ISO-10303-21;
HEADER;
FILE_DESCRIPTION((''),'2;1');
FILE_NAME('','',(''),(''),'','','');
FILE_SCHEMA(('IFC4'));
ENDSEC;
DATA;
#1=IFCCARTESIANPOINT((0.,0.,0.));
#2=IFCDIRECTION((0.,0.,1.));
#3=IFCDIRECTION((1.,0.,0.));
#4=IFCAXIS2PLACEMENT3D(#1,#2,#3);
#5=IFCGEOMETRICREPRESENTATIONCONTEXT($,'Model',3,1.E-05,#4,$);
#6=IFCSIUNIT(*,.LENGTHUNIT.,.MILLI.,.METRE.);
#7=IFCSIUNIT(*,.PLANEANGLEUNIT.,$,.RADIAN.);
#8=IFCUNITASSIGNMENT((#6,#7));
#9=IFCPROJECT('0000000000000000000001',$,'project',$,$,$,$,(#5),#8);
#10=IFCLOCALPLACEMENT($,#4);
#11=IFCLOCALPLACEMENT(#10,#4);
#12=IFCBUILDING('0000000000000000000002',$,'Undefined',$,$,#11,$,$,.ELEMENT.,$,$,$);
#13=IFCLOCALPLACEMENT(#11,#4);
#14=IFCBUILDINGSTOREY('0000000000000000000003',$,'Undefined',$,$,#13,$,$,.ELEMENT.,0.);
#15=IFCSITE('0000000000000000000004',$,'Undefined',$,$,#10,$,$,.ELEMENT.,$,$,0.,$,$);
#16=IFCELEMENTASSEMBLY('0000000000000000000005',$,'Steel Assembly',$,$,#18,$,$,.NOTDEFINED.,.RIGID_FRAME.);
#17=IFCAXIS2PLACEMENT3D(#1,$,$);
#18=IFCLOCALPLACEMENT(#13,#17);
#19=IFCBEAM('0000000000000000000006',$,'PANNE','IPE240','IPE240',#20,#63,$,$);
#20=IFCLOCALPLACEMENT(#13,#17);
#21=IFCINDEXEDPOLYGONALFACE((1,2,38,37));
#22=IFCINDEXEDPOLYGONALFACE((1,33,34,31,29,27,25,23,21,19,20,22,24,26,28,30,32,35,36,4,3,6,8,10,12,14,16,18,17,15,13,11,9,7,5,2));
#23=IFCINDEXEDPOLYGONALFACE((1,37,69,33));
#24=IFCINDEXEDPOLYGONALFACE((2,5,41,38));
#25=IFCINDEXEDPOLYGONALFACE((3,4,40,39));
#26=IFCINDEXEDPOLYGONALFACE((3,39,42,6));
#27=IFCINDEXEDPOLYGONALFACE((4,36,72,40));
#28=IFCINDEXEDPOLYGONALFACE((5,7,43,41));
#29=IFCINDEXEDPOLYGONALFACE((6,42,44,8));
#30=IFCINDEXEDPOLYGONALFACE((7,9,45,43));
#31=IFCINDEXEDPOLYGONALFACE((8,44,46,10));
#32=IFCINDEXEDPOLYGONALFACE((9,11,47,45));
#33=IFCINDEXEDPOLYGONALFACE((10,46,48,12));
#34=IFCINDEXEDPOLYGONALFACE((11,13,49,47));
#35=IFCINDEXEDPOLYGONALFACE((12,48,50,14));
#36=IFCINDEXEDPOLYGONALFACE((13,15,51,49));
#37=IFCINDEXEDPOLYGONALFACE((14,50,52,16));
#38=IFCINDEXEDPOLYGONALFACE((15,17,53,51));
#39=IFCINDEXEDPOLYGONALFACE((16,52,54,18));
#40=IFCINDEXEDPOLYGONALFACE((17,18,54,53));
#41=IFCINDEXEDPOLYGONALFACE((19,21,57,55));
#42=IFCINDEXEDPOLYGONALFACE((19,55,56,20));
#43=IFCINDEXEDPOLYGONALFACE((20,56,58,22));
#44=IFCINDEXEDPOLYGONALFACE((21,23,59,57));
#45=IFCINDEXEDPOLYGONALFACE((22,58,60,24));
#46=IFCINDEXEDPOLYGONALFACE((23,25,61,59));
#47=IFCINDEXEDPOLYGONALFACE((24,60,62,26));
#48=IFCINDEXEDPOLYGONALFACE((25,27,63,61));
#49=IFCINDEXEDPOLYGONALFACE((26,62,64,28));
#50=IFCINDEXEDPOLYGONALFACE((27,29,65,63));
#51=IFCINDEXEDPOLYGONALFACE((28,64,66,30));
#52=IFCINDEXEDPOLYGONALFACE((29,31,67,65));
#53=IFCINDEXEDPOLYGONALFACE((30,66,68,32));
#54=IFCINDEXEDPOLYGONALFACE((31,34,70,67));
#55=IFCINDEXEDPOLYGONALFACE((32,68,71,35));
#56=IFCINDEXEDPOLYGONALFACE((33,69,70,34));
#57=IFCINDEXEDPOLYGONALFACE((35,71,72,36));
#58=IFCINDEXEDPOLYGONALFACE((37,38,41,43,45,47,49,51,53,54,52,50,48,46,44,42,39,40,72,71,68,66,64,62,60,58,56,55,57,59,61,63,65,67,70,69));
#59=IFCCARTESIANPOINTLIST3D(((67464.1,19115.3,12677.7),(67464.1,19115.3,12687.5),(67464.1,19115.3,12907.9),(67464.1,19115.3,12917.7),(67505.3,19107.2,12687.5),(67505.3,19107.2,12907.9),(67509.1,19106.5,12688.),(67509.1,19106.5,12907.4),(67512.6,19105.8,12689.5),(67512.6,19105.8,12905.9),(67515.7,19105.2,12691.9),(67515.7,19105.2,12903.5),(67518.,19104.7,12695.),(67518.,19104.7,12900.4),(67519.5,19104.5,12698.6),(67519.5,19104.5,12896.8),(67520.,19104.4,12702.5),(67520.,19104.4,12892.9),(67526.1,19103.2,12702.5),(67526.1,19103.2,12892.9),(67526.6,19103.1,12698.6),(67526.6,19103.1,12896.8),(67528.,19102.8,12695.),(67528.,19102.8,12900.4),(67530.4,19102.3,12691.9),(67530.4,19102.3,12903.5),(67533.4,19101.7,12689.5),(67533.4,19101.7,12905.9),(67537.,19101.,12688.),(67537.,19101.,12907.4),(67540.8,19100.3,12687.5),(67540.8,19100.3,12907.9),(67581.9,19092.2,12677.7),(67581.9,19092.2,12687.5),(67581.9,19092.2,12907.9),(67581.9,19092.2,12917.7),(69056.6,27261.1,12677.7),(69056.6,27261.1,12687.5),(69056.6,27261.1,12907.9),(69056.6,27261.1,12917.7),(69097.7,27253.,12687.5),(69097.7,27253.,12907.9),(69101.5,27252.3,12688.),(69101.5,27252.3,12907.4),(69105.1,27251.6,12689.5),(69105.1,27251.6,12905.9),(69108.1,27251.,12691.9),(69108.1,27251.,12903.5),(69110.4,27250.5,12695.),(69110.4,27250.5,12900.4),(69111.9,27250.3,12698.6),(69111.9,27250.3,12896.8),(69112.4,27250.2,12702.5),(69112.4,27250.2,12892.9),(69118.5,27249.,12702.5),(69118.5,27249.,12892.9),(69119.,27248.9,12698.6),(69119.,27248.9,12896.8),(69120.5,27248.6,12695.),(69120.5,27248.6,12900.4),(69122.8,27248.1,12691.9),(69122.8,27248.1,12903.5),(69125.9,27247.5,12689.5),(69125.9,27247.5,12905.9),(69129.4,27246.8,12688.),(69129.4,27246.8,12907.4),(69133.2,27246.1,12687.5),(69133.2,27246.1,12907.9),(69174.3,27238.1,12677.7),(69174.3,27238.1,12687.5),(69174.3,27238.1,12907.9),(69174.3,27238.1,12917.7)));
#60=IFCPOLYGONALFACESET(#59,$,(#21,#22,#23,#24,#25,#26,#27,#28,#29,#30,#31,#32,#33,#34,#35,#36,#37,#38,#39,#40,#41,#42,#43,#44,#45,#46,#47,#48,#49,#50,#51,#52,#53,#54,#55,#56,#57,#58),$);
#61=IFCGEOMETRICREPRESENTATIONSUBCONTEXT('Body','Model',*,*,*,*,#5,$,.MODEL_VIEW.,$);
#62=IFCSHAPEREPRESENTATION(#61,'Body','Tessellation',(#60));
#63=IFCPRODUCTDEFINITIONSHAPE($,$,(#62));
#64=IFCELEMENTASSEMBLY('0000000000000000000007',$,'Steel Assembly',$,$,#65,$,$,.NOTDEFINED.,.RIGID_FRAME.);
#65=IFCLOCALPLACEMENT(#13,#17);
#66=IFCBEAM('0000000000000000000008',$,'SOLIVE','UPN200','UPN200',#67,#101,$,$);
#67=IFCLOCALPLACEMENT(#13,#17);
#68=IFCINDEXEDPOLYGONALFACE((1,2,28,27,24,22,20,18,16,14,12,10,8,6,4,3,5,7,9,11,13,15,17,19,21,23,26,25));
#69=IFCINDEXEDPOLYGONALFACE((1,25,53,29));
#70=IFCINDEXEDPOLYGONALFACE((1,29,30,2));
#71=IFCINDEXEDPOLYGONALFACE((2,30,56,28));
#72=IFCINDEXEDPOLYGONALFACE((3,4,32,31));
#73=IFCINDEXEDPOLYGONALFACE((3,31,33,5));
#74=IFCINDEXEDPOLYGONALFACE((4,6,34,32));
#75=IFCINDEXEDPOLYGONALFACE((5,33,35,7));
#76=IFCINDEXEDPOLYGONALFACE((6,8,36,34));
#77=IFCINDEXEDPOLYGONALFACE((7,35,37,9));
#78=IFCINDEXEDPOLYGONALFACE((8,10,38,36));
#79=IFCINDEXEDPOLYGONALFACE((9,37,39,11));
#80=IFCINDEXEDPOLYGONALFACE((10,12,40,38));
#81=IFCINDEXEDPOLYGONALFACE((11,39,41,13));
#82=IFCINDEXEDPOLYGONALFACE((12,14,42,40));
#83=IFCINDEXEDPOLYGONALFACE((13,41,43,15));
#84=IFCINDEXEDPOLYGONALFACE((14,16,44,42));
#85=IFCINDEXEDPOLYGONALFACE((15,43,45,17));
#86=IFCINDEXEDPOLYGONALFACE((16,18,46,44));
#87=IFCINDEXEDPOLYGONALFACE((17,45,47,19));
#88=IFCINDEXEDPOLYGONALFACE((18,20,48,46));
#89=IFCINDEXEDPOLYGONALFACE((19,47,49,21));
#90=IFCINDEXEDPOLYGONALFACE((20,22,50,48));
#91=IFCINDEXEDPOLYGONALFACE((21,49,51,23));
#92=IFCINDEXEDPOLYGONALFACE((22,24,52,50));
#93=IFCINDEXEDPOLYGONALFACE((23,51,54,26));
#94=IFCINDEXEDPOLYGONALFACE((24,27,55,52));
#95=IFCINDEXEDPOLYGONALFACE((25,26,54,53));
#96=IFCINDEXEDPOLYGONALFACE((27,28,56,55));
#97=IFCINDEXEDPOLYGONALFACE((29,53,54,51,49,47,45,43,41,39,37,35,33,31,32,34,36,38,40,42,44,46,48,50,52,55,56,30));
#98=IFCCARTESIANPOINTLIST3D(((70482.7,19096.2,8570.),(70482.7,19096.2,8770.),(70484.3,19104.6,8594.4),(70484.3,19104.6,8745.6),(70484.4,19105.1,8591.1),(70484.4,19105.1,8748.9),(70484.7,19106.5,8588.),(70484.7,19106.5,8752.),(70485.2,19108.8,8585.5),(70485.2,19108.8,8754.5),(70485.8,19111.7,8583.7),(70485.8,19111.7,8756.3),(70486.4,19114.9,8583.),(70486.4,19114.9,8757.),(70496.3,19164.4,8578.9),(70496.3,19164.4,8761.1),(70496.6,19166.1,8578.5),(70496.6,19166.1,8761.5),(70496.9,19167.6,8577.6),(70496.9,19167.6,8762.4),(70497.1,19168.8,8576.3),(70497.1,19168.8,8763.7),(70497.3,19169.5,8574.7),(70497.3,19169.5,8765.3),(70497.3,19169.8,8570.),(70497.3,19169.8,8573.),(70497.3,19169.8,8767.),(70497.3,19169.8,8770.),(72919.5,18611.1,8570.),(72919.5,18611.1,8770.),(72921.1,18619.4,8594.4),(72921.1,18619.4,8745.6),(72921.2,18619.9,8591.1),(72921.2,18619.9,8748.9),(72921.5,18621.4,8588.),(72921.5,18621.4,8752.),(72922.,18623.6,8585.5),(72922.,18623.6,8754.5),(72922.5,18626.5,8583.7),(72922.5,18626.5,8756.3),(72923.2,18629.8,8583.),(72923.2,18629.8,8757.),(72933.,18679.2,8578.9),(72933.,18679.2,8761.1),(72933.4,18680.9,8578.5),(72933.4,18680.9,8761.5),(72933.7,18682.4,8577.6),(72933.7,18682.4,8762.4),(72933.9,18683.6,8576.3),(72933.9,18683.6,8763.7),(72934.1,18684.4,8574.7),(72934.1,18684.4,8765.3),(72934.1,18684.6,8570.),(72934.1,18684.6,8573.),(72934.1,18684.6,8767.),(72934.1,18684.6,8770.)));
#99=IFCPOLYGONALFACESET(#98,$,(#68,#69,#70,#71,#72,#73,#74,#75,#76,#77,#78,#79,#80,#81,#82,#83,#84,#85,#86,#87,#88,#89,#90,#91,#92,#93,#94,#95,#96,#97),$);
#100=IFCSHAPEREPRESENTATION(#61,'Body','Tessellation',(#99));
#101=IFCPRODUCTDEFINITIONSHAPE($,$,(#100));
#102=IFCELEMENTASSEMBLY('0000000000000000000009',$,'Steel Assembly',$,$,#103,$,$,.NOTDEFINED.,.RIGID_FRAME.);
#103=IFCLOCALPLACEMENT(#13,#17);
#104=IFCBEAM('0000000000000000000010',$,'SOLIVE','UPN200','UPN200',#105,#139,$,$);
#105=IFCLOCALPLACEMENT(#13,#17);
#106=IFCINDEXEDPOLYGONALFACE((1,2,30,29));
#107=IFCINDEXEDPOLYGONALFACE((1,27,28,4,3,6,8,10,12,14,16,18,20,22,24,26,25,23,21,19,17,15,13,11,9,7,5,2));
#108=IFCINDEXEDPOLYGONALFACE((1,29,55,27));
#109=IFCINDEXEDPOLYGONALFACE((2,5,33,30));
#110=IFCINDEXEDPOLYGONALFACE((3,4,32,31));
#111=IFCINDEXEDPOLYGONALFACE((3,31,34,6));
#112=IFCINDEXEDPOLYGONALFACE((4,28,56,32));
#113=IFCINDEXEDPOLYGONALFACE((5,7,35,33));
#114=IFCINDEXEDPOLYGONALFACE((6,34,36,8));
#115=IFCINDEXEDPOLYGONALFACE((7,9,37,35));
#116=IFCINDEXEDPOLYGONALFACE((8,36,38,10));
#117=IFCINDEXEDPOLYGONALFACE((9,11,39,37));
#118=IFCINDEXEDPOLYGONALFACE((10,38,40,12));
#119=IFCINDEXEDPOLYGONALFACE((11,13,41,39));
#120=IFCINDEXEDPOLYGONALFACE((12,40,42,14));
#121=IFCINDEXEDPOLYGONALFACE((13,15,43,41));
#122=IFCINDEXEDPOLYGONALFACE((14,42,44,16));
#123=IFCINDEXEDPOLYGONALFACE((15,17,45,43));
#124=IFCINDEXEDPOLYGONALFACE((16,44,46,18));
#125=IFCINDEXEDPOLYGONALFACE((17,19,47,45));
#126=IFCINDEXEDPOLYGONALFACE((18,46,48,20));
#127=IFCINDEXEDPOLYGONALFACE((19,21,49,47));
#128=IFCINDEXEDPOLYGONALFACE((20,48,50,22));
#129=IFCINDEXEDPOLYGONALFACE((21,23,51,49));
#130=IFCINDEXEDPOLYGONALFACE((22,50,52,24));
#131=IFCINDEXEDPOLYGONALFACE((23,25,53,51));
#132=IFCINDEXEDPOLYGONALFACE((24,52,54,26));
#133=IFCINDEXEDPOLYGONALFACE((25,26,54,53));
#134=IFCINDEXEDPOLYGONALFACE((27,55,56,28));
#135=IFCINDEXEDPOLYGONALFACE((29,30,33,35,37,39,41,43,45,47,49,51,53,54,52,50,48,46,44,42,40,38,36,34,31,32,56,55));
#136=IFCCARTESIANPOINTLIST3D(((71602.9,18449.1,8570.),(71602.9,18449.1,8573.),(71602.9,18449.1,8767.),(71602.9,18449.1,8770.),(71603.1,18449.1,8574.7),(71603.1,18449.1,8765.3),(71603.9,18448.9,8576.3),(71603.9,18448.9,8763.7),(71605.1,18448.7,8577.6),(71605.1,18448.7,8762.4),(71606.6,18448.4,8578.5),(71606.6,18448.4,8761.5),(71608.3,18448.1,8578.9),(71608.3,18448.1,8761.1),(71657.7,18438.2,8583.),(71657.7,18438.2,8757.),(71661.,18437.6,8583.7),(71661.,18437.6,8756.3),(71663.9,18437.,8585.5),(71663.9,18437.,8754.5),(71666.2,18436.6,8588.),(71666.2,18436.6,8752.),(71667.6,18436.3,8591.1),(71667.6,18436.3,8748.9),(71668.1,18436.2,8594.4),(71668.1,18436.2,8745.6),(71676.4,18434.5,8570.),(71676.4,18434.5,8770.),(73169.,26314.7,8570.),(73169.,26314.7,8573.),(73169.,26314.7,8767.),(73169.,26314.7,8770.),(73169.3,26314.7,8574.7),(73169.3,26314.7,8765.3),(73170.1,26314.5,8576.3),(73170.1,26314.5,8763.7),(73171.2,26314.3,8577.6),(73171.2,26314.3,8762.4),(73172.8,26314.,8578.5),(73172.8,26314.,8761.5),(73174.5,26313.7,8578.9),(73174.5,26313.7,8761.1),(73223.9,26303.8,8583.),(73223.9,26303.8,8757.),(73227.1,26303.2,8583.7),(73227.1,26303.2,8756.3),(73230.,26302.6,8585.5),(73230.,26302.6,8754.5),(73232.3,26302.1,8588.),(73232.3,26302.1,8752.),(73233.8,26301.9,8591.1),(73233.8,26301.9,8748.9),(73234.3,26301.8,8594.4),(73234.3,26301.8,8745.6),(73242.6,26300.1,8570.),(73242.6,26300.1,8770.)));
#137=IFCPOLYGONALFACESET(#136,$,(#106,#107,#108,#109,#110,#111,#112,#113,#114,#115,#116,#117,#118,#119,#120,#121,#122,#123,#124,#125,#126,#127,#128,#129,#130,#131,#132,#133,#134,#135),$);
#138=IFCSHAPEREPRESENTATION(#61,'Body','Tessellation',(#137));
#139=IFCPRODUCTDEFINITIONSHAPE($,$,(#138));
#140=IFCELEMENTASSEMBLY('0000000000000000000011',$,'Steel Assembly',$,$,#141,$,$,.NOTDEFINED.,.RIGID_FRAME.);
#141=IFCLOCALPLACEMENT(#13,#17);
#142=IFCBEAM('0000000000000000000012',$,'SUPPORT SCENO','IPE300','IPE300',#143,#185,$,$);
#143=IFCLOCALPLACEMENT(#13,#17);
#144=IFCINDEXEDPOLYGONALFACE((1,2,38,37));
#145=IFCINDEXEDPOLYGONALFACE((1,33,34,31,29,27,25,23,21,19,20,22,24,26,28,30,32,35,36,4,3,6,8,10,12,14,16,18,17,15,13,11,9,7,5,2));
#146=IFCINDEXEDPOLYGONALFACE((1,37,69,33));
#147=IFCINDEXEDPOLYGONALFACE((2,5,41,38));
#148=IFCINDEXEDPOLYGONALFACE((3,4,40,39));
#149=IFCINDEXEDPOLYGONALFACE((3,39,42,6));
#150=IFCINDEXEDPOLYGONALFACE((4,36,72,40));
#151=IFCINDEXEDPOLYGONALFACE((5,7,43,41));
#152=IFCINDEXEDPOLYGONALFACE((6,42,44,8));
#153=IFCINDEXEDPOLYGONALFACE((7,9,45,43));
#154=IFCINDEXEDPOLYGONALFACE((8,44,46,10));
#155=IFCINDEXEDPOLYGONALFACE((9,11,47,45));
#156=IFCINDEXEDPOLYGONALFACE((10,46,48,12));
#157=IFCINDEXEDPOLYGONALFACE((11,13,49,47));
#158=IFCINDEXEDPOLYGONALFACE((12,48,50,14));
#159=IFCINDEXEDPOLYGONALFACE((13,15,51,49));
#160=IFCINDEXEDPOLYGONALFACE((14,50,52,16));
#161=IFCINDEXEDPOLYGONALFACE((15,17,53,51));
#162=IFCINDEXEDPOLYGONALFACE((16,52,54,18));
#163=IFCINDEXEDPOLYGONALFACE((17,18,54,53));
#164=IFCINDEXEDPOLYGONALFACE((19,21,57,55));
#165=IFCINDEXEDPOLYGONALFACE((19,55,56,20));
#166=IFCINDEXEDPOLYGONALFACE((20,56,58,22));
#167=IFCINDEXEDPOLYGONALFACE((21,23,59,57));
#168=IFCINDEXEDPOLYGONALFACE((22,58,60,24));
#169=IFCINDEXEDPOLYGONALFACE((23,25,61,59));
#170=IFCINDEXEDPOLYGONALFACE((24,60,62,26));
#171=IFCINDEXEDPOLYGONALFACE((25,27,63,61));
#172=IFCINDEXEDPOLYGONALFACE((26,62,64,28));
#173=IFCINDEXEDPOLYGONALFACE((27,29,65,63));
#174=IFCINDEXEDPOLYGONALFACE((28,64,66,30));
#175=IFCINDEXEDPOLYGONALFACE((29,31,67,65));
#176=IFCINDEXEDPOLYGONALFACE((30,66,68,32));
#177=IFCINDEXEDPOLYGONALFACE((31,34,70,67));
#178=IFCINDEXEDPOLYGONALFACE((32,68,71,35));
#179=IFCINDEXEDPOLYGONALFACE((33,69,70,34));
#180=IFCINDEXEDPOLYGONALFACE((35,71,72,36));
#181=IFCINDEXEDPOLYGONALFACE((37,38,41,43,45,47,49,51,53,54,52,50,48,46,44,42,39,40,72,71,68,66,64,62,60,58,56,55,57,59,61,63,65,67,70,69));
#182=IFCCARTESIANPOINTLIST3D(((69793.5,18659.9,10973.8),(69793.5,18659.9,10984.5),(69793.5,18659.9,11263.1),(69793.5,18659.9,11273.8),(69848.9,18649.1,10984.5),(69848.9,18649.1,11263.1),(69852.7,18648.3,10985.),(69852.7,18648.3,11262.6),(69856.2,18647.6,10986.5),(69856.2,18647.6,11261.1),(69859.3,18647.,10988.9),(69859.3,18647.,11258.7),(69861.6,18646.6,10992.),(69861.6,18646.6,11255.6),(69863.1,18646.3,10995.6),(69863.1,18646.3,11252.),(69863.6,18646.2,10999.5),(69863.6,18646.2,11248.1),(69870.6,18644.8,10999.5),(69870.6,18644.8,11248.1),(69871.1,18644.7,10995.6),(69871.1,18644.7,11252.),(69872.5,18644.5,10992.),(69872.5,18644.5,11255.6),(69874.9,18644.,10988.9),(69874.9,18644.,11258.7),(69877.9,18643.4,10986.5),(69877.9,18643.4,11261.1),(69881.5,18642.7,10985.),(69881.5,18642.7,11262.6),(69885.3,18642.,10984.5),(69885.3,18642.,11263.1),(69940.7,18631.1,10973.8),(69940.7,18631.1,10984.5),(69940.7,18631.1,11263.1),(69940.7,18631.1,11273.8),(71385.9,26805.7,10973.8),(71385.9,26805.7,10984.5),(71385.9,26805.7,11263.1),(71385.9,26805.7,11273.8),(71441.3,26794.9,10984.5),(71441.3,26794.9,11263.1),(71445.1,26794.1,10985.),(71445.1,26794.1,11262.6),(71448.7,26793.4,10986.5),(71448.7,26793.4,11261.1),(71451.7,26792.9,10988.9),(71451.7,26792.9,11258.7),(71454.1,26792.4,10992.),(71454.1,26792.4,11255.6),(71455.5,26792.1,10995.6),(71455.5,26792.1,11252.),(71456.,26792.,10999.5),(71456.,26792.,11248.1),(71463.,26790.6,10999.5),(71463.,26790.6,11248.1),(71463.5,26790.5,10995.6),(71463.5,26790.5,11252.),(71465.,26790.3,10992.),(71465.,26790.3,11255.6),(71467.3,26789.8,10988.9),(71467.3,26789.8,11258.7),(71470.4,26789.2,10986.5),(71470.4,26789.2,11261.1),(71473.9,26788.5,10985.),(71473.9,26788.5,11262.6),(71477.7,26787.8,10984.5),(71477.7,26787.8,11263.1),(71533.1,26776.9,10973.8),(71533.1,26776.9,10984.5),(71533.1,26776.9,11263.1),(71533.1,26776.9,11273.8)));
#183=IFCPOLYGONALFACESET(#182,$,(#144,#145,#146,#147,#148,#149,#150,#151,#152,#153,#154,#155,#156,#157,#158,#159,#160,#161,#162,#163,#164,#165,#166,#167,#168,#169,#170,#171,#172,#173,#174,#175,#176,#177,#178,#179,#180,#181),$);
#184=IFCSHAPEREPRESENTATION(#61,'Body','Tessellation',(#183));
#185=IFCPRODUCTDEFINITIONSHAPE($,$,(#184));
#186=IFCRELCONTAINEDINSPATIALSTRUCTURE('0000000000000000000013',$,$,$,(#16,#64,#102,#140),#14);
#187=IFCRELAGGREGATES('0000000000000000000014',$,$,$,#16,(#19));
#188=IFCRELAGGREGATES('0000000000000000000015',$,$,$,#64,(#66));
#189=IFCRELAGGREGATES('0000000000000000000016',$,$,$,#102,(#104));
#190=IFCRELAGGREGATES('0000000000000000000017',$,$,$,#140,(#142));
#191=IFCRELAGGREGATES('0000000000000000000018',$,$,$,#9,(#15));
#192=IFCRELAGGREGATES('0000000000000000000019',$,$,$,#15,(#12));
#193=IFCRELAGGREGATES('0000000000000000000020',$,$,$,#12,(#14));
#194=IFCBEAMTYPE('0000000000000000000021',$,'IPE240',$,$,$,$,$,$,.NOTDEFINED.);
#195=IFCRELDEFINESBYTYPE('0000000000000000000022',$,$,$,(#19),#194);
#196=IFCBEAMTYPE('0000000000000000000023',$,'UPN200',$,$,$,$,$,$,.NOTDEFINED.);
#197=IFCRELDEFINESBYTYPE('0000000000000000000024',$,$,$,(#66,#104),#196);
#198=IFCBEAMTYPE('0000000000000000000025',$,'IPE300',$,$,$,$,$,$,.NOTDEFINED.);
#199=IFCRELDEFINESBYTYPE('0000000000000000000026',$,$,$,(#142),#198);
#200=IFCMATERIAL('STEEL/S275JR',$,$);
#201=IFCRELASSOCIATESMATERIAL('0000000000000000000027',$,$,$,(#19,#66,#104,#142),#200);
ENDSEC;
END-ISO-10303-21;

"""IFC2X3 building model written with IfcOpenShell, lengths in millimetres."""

from ifc_helpers import new_model, si_unit, frame, origin_with_axes, origin_2d_with_axis, place, context, subcontext, project, spatial, i_section, u_section, extrude, material, type_object, element, aggregate, save


model = new_model("IFC2X3")

# Units and contexts
model_context = context("Model", 3, precision=1e-05, world=origin_with_axes())
body_context = subcontext(model_context, "Body", "Model", "MODEL_VIEW")
ifc_project = project(units=[si_unit("LENGTHUNIT", "METRE", prefix="MILLI"), si_unit("PLANEANGLEUNIT", "RADIAN")], contexts=[model_context])

# Site, building, storey
site_placement = place(None, origin_with_axes())
site = spatial("IfcSite", under=ifc_project, at=site_placement, Name="Undefined", CompositionType="ELEMENT", RefElevation=0.0)
building_placement = place(site_placement, origin_with_axes())
building = spatial("IfcBuilding", under=site, at=building_placement, Name="Undefined", CompositionType="ELEMENT")
storey_placement = place(building_placement, origin_with_axes())
storey = spatial("IfcBuildingStorey", under=building, at=storey_placement, Name="Undefined", CompositionType="ELEMENT", Elevation=0.0)

# Element assemblies, beams
assembly_1_placement = place(storey_placement, origin_with_axes())
assembly_1 = element("IfcElementAssembly", 1, at=assembly_1_placement, inside=storey, Name="Steel Assembly", AssemblyPlace="NOTDEFINED", PredefinedType="RIGID_FRAME")
ifc_material = material(Name="STEEL/S275JR")
beam_type_1 = type_object("IfcBeamType", Name="IPE240", PredefinedType="NOTDEFINED")
beam_1_placement = place(assembly_1_placement, frame((67523.0, 19103.8, 12797.7), z_axis=(0.0, 0.0, 1.0), x_axis=(0.191859, 0.981422, 0.0)))
beam_1 = element("IfcBeam", 2, at=beam_1_placement, type_object=beam_type_1, material=ifc_material, Name="PANNE", Description="IPE240", ObjectType="IPE240", context=body_context, shape_type="SweptSolid", body=[
    extrude(i_section(OverallWidth=120.0, OverallDepth=240.0, WebThickness=6.2, FlangeThickness=9.8, FilletRadius=15.0, at=origin_2d_with_axis()), frame((8300.0, 0.0, 0.0), z_axis=(-1.0, 0.0, 0.0), x_axis=(0.0, -1.0, 0.0)), (0.0, 0.0, 1.0), 8300.0),
])
aggregate(assembly_1, [beam_1])
assembly_2_placement = place(storey_placement, origin_with_axes())
assembly_2 = element("IfcElementAssembly", 3, at=assembly_2_placement, inside=storey, Name="Steel Assembly", AssemblyPlace="NOTDEFINED", PredefinedType="RIGID_FRAME")
beam_type_2 = type_object("IfcBeamType", Name="UPN200", PredefinedType="NOTDEFINED")
beam_2_placement = place(assembly_2_placement, frame((70490.0, 19133.0, 8670.0), z_axis=(0.0, 0.0, -1.0), x_axis=(0.980752, -0.19526, 0.0)))
beam_2 = element("IfcBeam", 4, at=beam_2_placement, type_object=beam_type_2, material=ifc_material, Name="SOLIVE", Description="UPN200", ObjectType="UPN200", context=body_context, shape_type="SweptSolid", body=[
    extrude(u_section(Depth=200.0, FlangeWidth=75.0, WebThickness=8.5, FlangeThickness=11.5, FilletRadius=11.5, EdgeRadius=6.0, FlangeSlope=0.07983, at=origin_2d_with_axis()), frame((2484.6, 0.0, 0.0), z_axis=(-1.0, 0.0, 0.0), x_axis=(0.0, -1.0, 0.0)), (0.0, 0.0, 1.0), 2484.6),
])
aggregate(assembly_2, [beam_2])
assembly_3_placement = place(storey_placement, origin_with_axes())
assembly_3 = element("IfcElementAssembly", 5, at=assembly_3_placement, inside=storey, Name="Steel Assembly", AssemblyPlace="NOTDEFINED", PredefinedType="RIGID_FRAME")
beam_3_placement = place(assembly_3_placement, frame((71639.7, 18441.8, 8670.0), z_axis=(0.0, 0.0, -1.0), x_axis=(0.195281, 0.980747, 0.0)))
beam_3 = element("IfcBeam", 6, at=beam_3_placement, type_object=beam_type_2, material=ifc_material, Name="SOLIVE", Description="UPN200", ObjectType="UPN200", context=body_context, shape_type="SweptSolid", body=[
    extrude(u_section(Depth=200.0, FlangeWidth=75.0, WebThickness=8.5, FlangeThickness=11.5, FilletRadius=11.5, EdgeRadius=6.0, FlangeSlope=0.07983, at=origin_2d_with_axis()), frame((8020.0, 0.0, 0.0), z_axis=(-1.0, 0.0, 0.0), x_axis=(0.0, -1.0, 0.0)), (0.0, 0.0, 1.0), 8020.0),
])
aggregate(assembly_3, [beam_3])
assembly_4_placement = place(storey_placement, origin_with_axes())
assembly_4 = element("IfcElementAssembly", 7, at=assembly_4_placement, inside=storey, Name="Steel Assembly", AssemblyPlace="NOTDEFINED", PredefinedType="RIGID_FRAME")
beam_type_3 = type_object("IfcBeamType", Name="IPE300", PredefinedType="NOTDEFINED")
beam_4_placement = place(assembly_4_placement, frame((69867.1, 18645.5, 11123.8), z_axis=(0.0, 0.0, 1.0), x_axis=(0.191859, 0.981422, 0.0)))
beam_4 = element("IfcBeam", 8, at=beam_4_placement, type_object=beam_type_3, material=ifc_material, Name="SUPPORT SCENO", Description="IPE300", ObjectType="IPE300", context=body_context, shape_type="SweptSolid", body=[
    extrude(i_section(OverallWidth=150.0, OverallDepth=300.0, WebThickness=7.1, FlangeThickness=10.7, FilletRadius=15.0, at=origin_2d_with_axis()), frame((8300.0, 0.0, 0.0), z_axis=(-1.0, 0.0, 0.0), x_axis=(0.0, -1.0, 0.0)), (0.0, 0.0, 1.0), 8300.0),
])
aggregate(assembly_4, [beam_4])

save(model, "model.ifc")
